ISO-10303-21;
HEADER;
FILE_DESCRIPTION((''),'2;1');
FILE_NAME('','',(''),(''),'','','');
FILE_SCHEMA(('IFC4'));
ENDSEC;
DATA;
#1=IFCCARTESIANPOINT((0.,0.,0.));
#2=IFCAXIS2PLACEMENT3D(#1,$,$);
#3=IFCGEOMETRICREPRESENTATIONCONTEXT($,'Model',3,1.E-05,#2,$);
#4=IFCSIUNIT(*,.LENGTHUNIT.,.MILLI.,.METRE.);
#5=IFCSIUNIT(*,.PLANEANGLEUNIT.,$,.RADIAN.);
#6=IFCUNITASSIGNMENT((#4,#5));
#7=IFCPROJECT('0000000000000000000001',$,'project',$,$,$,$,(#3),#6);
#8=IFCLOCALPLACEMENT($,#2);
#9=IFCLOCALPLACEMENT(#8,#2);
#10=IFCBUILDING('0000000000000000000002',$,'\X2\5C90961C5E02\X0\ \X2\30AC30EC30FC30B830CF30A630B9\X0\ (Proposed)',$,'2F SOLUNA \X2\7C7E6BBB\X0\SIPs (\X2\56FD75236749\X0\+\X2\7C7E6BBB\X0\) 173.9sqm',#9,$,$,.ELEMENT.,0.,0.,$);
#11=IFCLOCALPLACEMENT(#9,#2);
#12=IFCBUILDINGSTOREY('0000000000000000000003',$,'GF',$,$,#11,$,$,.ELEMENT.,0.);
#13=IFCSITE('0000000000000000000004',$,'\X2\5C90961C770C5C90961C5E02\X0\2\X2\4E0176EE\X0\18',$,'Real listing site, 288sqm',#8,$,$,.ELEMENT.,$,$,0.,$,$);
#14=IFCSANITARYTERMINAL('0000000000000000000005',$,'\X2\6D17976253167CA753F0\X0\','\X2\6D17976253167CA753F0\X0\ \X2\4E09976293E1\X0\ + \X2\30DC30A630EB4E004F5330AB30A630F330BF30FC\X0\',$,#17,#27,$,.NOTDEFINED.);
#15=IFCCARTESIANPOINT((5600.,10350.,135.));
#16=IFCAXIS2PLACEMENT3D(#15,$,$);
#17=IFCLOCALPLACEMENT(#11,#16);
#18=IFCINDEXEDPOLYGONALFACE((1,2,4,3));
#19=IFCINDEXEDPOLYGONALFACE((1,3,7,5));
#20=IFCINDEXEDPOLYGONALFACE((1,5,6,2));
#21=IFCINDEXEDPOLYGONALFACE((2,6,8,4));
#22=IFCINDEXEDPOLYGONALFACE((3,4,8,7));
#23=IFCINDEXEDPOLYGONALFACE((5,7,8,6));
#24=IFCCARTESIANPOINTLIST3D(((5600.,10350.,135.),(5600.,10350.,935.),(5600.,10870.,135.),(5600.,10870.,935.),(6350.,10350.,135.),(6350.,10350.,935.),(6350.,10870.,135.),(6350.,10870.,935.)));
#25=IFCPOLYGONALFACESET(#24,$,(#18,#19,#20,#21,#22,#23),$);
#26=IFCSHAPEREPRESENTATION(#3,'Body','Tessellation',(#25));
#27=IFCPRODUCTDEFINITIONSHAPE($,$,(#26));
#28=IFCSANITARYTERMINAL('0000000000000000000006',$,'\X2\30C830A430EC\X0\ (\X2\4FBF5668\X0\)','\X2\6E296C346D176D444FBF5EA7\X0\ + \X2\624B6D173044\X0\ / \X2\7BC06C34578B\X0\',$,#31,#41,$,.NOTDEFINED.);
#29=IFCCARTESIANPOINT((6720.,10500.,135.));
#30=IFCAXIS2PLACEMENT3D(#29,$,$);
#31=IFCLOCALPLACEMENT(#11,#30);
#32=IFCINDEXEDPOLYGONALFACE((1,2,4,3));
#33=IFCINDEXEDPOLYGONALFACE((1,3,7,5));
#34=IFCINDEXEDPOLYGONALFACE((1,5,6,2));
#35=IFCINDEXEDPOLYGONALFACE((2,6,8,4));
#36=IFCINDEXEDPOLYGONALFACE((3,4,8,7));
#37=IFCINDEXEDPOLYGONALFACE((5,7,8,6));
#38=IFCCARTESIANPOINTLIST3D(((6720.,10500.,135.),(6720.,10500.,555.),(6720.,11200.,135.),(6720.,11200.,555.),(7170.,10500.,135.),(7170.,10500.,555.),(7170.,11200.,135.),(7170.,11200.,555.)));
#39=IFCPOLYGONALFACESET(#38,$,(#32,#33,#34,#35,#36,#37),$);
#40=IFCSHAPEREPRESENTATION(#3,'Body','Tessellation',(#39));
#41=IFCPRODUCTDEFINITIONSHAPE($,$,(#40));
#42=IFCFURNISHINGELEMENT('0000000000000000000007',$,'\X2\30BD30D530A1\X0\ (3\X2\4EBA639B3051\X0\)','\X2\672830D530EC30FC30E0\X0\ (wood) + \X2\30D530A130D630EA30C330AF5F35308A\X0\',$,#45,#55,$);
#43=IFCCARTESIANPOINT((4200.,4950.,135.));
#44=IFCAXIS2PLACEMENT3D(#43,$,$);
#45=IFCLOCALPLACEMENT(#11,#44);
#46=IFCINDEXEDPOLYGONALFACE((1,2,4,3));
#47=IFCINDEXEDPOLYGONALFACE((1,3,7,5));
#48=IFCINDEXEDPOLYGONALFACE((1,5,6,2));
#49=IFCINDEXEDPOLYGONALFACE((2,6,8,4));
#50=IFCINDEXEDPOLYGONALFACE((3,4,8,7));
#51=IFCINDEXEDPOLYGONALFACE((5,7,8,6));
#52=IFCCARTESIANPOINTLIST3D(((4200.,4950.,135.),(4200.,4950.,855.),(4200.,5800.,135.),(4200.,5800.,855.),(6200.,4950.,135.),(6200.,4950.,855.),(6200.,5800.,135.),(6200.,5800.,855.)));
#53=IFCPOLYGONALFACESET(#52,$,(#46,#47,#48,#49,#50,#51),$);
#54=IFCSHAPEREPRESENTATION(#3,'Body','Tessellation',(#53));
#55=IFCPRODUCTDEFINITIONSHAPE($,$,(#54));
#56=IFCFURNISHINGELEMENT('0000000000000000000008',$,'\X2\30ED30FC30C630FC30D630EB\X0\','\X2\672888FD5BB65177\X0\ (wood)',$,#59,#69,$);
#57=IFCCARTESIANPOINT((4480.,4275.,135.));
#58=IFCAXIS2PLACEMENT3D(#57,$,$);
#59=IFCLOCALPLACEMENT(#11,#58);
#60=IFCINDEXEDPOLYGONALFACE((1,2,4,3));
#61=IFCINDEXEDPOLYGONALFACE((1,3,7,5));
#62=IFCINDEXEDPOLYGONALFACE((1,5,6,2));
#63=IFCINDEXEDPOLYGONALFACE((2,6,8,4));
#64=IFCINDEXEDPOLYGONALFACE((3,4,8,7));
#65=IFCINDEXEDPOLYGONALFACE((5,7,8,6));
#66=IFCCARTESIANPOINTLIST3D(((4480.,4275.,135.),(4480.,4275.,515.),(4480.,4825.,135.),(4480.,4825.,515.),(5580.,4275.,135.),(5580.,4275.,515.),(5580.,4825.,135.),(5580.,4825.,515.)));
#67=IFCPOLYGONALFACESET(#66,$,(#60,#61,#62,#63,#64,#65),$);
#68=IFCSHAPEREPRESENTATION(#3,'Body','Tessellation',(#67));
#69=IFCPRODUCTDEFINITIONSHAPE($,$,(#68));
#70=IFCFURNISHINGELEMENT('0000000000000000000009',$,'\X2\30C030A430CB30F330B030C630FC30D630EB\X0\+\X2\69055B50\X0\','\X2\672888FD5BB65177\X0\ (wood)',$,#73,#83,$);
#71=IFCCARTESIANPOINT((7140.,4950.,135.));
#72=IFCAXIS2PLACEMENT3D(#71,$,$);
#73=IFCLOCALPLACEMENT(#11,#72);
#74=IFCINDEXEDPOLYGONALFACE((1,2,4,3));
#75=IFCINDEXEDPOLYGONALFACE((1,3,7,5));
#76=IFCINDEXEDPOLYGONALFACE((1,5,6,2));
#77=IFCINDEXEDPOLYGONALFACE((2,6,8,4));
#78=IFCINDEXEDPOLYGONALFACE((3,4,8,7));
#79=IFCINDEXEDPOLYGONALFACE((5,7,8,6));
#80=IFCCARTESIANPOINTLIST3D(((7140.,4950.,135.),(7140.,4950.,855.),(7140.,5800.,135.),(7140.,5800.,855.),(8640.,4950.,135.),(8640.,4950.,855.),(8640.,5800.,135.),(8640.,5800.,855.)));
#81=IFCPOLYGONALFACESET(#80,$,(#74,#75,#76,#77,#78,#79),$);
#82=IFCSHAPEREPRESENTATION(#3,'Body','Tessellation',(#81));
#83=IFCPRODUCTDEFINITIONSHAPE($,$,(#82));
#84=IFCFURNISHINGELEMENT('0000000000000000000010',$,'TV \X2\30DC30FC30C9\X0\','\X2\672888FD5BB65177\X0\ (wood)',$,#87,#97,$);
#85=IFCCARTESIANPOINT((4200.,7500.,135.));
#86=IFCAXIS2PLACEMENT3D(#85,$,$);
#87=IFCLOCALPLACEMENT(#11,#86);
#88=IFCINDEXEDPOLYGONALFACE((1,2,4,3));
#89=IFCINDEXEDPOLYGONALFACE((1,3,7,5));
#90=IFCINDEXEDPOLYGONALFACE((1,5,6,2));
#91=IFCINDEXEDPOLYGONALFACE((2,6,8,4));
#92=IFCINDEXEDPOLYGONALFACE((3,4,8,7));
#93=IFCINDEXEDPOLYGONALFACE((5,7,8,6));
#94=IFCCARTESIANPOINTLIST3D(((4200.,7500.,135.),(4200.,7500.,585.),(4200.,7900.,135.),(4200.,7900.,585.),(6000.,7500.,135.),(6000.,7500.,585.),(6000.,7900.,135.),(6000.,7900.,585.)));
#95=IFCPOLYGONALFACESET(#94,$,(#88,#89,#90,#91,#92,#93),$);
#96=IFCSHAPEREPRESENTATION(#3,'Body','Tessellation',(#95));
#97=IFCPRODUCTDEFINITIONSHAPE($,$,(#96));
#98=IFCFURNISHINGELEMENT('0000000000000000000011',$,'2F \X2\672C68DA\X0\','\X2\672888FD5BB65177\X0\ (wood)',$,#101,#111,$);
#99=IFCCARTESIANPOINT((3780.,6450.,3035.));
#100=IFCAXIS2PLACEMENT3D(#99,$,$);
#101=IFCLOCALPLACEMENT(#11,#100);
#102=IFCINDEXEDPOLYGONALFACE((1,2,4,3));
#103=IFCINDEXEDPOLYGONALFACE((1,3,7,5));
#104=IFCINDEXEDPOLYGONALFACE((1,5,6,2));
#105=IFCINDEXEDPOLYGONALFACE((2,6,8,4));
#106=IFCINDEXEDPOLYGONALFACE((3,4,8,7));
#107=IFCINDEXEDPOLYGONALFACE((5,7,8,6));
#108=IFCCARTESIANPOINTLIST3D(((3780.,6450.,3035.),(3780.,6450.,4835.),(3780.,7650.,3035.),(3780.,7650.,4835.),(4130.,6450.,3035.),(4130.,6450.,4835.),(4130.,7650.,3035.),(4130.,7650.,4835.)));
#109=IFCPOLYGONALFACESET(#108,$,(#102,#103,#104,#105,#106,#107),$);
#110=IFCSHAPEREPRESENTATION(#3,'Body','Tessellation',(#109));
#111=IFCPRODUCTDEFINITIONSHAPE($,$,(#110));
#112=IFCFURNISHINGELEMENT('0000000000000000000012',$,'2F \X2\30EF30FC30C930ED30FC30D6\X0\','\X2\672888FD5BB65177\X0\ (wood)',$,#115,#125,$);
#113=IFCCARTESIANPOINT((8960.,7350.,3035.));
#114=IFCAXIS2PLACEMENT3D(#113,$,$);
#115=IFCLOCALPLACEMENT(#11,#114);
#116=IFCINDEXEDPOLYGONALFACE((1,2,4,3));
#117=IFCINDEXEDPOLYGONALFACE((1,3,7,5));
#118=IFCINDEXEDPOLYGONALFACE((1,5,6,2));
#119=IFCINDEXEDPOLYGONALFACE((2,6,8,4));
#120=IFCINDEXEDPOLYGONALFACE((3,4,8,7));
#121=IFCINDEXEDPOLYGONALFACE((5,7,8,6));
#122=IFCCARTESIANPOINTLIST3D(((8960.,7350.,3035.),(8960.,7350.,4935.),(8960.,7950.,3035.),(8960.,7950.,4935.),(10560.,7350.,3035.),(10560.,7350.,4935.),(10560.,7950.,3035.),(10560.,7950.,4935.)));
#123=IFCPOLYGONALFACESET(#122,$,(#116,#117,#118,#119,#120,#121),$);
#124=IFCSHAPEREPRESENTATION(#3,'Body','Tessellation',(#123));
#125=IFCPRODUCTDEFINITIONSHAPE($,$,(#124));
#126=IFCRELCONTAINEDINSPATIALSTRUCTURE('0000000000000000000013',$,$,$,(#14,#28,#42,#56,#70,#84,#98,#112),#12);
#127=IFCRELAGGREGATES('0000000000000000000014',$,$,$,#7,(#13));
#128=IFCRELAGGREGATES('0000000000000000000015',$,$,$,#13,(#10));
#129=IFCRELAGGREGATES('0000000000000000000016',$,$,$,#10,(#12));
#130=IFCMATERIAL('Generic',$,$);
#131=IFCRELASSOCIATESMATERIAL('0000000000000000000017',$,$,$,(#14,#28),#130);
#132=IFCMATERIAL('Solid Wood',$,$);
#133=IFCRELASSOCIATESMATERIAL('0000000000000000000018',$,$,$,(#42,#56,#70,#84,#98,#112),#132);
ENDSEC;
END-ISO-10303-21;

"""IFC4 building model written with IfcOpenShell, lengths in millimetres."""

from ifc_helpers import new_model, si_unit, frame, frame_2d, origin, place, context, project, spatial, rectangle, extrude, material, element, save


model = new_model("IFC4")

# Units and contexts
model_context = context("Model", 3, precision=1e-05, world=origin())
ifc_project = project(units=[si_unit("LENGTHUNIT", "METRE", prefix="MILLI"), si_unit("PLANEANGLEUNIT", "RADIAN")], contexts=[model_context])

# Site, building, storey
site_placement = place(None, origin())
site = spatial("IfcSite", under=ifc_project, at=site_placement, Name="岐阜県岐阜市2丁目18", ObjectType="Real listing site, 288sqm", CompositionType="ELEMENT", RefElevation=0.0)
building_placement = place(site_placement, origin())
building = spatial("IfcBuilding", under=site, at=building_placement, Name="岐阜市 ガレージハウス (Proposed)", ObjectType="2F SOLUNA 籾殻SIPs (国産杉+籾殻) 173.9sqm", CompositionType="ELEMENT", ElevationOfRefHeight=0.0, ElevationOfTerrain=0.0)
storey_placement = place(building_placement, origin())
storey = spatial("IfcBuildingStorey", under=building, at=storey_placement, Name="GF", CompositionType="ELEMENT", Elevation=0.0)

# Shared definitions
ifc_material_1 = material(Name="Generic")

# Shared definitions
ifc_material_2 = material(Name="Solid Wood")

# Sanitary terminals
sanitary_terminal_1_placement = place(storey_placement, frame((5600.0, 10350.0, 135.0)))
element("IfcSanitaryTerminal", 1, at=sanitary_terminal_1_placement, inside=storey, material=ifc_material_1, Name="洗面化粧台", Description="洗面化粧台 三面鏡 + ボウル一体カウンター", PredefinedType="NOTDEFINED", context=model_context, shape_type="SweptSolid", body=[
    extrude(rectangle(XDim=750.0, YDim=520.0, at=frame_2d((375.0, 260.0))), frame((5600.0, 10350.0, 135.0)), (0.0, 0.0, 1.0), 800.0),
])
sanitary_terminal_2_placement = place(storey_placement, frame((6720.0, 10500.0, 135.0)))
element("IfcSanitaryTerminal", 2, at=sanitary_terminal_2_placement, inside=storey, material=ifc_material_1, Name="トイレ (便器)", Description="温水洗浄便座 + 手洗い / 節水型", PredefinedType="NOTDEFINED", context=model_context, shape_type="SweptSolid", body=[
    extrude(rectangle(XDim=450.0, YDim=700.0, at=frame_2d((225.0, 350.0))), frame((6720.0, 10500.0, 135.0)), (0.0, 0.0, 1.0), 420.0),
])

# Furnishing elements
furnishing_1_placement = place(storey_placement, frame((4200.0, 4950.0, 135.0)))
element("IfcFurnishingElement", 3, at=furnishing_1_placement, inside=storey, material=ifc_material_2, Name="ソファ (3人掛け)", Description="木フレーム (wood) + ファブリック張り", context=model_context, shape_type="SweptSolid", body=[
    extrude(rectangle(XDim=2000.0, YDim=850.0, at=frame_2d((1000.0, 425.0))), frame((4200.0, 4950.0, 135.0)), (0.0, 0.0, 1.0), 720.0),
])
furnishing_2_placement = place(storey_placement, frame((4480.0, 4275.0, 135.0)))
element("IfcFurnishingElement", 4, at=furnishing_2_placement, inside=storey, material=ifc_material_2, Name="ローテーブル", Description="木製家具 (wood)", context=model_context, shape_type="SweptSolid", body=[
    extrude(rectangle(XDim=1100.0, YDim=550.0, at=frame_2d((550.0, 275.0))), frame((4480.0, 4275.0, 135.0)), (0.0, 0.0, 1.0), 380.0),
])
furnishing_3_placement = place(storey_placement, frame((7140.0, 4950.0, 135.0)))
element("IfcFurnishingElement", 5, at=furnishing_3_placement, inside=storey, material=ifc_material_2, Name="ダイニングテーブル+椅子", Description="木製家具 (wood)", context=model_context, shape_type="SweptSolid", body=[
    extrude(rectangle(XDim=1500.0, YDim=850.0, at=frame_2d((750.0, 425.0))), frame((7140.0, 4950.0, 135.0)), (0.0, 0.0, 1.0), 720.0),
])
furnishing_4_placement = place(storey_placement, frame((4200.0, 7500.0, 135.0)))
element("IfcFurnishingElement", 6, at=furnishing_4_placement, inside=storey, material=ifc_material_2, Name="TV ボード", Description="木製家具 (wood)", context=model_context, shape_type="SweptSolid", body=[
    extrude(rectangle(XDim=1800.0, YDim=400.0, at=frame_2d((900.0, 200.0))), frame((4200.0, 7500.0, 135.0)), (0.0, 0.0, 1.0), 450.0),
])
furnishing_5_placement = place(storey_placement, frame((3780.0, 6450.0, 3035.0)))
element("IfcFurnishingElement", 7, at=furnishing_5_placement, inside=storey, material=ifc_material_2, Name="2F 本棚", Description="木製家具 (wood)", context=model_context, shape_type="SweptSolid", body=[
    extrude(rectangle(XDim=350.0, YDim=1200.0, at=frame_2d((175.0, 600.0))), frame((3780.0, 6450.0, 3035.0)), (0.0, 0.0, 1.0), 1800.0),
])
furnishing_6_placement = place(storey_placement, frame((8960.0, 7350.0, 3035.0)))
element("IfcFurnishingElement", 8, at=furnishing_6_placement, inside=storey, material=ifc_material_2, Name="2F ワードローブ", Description="木製家具 (wood)", context=model_context, shape_type="SweptSolid", body=[
    extrude(rectangle(XDim=1600.0, YDim=600.0, at=frame_2d((800.0, 300.0))), frame((8960.0, 7350.0, 3035.0)), (0.0, 0.0, 1.0), 1900.0),
])

save(model, "model.ifc")
